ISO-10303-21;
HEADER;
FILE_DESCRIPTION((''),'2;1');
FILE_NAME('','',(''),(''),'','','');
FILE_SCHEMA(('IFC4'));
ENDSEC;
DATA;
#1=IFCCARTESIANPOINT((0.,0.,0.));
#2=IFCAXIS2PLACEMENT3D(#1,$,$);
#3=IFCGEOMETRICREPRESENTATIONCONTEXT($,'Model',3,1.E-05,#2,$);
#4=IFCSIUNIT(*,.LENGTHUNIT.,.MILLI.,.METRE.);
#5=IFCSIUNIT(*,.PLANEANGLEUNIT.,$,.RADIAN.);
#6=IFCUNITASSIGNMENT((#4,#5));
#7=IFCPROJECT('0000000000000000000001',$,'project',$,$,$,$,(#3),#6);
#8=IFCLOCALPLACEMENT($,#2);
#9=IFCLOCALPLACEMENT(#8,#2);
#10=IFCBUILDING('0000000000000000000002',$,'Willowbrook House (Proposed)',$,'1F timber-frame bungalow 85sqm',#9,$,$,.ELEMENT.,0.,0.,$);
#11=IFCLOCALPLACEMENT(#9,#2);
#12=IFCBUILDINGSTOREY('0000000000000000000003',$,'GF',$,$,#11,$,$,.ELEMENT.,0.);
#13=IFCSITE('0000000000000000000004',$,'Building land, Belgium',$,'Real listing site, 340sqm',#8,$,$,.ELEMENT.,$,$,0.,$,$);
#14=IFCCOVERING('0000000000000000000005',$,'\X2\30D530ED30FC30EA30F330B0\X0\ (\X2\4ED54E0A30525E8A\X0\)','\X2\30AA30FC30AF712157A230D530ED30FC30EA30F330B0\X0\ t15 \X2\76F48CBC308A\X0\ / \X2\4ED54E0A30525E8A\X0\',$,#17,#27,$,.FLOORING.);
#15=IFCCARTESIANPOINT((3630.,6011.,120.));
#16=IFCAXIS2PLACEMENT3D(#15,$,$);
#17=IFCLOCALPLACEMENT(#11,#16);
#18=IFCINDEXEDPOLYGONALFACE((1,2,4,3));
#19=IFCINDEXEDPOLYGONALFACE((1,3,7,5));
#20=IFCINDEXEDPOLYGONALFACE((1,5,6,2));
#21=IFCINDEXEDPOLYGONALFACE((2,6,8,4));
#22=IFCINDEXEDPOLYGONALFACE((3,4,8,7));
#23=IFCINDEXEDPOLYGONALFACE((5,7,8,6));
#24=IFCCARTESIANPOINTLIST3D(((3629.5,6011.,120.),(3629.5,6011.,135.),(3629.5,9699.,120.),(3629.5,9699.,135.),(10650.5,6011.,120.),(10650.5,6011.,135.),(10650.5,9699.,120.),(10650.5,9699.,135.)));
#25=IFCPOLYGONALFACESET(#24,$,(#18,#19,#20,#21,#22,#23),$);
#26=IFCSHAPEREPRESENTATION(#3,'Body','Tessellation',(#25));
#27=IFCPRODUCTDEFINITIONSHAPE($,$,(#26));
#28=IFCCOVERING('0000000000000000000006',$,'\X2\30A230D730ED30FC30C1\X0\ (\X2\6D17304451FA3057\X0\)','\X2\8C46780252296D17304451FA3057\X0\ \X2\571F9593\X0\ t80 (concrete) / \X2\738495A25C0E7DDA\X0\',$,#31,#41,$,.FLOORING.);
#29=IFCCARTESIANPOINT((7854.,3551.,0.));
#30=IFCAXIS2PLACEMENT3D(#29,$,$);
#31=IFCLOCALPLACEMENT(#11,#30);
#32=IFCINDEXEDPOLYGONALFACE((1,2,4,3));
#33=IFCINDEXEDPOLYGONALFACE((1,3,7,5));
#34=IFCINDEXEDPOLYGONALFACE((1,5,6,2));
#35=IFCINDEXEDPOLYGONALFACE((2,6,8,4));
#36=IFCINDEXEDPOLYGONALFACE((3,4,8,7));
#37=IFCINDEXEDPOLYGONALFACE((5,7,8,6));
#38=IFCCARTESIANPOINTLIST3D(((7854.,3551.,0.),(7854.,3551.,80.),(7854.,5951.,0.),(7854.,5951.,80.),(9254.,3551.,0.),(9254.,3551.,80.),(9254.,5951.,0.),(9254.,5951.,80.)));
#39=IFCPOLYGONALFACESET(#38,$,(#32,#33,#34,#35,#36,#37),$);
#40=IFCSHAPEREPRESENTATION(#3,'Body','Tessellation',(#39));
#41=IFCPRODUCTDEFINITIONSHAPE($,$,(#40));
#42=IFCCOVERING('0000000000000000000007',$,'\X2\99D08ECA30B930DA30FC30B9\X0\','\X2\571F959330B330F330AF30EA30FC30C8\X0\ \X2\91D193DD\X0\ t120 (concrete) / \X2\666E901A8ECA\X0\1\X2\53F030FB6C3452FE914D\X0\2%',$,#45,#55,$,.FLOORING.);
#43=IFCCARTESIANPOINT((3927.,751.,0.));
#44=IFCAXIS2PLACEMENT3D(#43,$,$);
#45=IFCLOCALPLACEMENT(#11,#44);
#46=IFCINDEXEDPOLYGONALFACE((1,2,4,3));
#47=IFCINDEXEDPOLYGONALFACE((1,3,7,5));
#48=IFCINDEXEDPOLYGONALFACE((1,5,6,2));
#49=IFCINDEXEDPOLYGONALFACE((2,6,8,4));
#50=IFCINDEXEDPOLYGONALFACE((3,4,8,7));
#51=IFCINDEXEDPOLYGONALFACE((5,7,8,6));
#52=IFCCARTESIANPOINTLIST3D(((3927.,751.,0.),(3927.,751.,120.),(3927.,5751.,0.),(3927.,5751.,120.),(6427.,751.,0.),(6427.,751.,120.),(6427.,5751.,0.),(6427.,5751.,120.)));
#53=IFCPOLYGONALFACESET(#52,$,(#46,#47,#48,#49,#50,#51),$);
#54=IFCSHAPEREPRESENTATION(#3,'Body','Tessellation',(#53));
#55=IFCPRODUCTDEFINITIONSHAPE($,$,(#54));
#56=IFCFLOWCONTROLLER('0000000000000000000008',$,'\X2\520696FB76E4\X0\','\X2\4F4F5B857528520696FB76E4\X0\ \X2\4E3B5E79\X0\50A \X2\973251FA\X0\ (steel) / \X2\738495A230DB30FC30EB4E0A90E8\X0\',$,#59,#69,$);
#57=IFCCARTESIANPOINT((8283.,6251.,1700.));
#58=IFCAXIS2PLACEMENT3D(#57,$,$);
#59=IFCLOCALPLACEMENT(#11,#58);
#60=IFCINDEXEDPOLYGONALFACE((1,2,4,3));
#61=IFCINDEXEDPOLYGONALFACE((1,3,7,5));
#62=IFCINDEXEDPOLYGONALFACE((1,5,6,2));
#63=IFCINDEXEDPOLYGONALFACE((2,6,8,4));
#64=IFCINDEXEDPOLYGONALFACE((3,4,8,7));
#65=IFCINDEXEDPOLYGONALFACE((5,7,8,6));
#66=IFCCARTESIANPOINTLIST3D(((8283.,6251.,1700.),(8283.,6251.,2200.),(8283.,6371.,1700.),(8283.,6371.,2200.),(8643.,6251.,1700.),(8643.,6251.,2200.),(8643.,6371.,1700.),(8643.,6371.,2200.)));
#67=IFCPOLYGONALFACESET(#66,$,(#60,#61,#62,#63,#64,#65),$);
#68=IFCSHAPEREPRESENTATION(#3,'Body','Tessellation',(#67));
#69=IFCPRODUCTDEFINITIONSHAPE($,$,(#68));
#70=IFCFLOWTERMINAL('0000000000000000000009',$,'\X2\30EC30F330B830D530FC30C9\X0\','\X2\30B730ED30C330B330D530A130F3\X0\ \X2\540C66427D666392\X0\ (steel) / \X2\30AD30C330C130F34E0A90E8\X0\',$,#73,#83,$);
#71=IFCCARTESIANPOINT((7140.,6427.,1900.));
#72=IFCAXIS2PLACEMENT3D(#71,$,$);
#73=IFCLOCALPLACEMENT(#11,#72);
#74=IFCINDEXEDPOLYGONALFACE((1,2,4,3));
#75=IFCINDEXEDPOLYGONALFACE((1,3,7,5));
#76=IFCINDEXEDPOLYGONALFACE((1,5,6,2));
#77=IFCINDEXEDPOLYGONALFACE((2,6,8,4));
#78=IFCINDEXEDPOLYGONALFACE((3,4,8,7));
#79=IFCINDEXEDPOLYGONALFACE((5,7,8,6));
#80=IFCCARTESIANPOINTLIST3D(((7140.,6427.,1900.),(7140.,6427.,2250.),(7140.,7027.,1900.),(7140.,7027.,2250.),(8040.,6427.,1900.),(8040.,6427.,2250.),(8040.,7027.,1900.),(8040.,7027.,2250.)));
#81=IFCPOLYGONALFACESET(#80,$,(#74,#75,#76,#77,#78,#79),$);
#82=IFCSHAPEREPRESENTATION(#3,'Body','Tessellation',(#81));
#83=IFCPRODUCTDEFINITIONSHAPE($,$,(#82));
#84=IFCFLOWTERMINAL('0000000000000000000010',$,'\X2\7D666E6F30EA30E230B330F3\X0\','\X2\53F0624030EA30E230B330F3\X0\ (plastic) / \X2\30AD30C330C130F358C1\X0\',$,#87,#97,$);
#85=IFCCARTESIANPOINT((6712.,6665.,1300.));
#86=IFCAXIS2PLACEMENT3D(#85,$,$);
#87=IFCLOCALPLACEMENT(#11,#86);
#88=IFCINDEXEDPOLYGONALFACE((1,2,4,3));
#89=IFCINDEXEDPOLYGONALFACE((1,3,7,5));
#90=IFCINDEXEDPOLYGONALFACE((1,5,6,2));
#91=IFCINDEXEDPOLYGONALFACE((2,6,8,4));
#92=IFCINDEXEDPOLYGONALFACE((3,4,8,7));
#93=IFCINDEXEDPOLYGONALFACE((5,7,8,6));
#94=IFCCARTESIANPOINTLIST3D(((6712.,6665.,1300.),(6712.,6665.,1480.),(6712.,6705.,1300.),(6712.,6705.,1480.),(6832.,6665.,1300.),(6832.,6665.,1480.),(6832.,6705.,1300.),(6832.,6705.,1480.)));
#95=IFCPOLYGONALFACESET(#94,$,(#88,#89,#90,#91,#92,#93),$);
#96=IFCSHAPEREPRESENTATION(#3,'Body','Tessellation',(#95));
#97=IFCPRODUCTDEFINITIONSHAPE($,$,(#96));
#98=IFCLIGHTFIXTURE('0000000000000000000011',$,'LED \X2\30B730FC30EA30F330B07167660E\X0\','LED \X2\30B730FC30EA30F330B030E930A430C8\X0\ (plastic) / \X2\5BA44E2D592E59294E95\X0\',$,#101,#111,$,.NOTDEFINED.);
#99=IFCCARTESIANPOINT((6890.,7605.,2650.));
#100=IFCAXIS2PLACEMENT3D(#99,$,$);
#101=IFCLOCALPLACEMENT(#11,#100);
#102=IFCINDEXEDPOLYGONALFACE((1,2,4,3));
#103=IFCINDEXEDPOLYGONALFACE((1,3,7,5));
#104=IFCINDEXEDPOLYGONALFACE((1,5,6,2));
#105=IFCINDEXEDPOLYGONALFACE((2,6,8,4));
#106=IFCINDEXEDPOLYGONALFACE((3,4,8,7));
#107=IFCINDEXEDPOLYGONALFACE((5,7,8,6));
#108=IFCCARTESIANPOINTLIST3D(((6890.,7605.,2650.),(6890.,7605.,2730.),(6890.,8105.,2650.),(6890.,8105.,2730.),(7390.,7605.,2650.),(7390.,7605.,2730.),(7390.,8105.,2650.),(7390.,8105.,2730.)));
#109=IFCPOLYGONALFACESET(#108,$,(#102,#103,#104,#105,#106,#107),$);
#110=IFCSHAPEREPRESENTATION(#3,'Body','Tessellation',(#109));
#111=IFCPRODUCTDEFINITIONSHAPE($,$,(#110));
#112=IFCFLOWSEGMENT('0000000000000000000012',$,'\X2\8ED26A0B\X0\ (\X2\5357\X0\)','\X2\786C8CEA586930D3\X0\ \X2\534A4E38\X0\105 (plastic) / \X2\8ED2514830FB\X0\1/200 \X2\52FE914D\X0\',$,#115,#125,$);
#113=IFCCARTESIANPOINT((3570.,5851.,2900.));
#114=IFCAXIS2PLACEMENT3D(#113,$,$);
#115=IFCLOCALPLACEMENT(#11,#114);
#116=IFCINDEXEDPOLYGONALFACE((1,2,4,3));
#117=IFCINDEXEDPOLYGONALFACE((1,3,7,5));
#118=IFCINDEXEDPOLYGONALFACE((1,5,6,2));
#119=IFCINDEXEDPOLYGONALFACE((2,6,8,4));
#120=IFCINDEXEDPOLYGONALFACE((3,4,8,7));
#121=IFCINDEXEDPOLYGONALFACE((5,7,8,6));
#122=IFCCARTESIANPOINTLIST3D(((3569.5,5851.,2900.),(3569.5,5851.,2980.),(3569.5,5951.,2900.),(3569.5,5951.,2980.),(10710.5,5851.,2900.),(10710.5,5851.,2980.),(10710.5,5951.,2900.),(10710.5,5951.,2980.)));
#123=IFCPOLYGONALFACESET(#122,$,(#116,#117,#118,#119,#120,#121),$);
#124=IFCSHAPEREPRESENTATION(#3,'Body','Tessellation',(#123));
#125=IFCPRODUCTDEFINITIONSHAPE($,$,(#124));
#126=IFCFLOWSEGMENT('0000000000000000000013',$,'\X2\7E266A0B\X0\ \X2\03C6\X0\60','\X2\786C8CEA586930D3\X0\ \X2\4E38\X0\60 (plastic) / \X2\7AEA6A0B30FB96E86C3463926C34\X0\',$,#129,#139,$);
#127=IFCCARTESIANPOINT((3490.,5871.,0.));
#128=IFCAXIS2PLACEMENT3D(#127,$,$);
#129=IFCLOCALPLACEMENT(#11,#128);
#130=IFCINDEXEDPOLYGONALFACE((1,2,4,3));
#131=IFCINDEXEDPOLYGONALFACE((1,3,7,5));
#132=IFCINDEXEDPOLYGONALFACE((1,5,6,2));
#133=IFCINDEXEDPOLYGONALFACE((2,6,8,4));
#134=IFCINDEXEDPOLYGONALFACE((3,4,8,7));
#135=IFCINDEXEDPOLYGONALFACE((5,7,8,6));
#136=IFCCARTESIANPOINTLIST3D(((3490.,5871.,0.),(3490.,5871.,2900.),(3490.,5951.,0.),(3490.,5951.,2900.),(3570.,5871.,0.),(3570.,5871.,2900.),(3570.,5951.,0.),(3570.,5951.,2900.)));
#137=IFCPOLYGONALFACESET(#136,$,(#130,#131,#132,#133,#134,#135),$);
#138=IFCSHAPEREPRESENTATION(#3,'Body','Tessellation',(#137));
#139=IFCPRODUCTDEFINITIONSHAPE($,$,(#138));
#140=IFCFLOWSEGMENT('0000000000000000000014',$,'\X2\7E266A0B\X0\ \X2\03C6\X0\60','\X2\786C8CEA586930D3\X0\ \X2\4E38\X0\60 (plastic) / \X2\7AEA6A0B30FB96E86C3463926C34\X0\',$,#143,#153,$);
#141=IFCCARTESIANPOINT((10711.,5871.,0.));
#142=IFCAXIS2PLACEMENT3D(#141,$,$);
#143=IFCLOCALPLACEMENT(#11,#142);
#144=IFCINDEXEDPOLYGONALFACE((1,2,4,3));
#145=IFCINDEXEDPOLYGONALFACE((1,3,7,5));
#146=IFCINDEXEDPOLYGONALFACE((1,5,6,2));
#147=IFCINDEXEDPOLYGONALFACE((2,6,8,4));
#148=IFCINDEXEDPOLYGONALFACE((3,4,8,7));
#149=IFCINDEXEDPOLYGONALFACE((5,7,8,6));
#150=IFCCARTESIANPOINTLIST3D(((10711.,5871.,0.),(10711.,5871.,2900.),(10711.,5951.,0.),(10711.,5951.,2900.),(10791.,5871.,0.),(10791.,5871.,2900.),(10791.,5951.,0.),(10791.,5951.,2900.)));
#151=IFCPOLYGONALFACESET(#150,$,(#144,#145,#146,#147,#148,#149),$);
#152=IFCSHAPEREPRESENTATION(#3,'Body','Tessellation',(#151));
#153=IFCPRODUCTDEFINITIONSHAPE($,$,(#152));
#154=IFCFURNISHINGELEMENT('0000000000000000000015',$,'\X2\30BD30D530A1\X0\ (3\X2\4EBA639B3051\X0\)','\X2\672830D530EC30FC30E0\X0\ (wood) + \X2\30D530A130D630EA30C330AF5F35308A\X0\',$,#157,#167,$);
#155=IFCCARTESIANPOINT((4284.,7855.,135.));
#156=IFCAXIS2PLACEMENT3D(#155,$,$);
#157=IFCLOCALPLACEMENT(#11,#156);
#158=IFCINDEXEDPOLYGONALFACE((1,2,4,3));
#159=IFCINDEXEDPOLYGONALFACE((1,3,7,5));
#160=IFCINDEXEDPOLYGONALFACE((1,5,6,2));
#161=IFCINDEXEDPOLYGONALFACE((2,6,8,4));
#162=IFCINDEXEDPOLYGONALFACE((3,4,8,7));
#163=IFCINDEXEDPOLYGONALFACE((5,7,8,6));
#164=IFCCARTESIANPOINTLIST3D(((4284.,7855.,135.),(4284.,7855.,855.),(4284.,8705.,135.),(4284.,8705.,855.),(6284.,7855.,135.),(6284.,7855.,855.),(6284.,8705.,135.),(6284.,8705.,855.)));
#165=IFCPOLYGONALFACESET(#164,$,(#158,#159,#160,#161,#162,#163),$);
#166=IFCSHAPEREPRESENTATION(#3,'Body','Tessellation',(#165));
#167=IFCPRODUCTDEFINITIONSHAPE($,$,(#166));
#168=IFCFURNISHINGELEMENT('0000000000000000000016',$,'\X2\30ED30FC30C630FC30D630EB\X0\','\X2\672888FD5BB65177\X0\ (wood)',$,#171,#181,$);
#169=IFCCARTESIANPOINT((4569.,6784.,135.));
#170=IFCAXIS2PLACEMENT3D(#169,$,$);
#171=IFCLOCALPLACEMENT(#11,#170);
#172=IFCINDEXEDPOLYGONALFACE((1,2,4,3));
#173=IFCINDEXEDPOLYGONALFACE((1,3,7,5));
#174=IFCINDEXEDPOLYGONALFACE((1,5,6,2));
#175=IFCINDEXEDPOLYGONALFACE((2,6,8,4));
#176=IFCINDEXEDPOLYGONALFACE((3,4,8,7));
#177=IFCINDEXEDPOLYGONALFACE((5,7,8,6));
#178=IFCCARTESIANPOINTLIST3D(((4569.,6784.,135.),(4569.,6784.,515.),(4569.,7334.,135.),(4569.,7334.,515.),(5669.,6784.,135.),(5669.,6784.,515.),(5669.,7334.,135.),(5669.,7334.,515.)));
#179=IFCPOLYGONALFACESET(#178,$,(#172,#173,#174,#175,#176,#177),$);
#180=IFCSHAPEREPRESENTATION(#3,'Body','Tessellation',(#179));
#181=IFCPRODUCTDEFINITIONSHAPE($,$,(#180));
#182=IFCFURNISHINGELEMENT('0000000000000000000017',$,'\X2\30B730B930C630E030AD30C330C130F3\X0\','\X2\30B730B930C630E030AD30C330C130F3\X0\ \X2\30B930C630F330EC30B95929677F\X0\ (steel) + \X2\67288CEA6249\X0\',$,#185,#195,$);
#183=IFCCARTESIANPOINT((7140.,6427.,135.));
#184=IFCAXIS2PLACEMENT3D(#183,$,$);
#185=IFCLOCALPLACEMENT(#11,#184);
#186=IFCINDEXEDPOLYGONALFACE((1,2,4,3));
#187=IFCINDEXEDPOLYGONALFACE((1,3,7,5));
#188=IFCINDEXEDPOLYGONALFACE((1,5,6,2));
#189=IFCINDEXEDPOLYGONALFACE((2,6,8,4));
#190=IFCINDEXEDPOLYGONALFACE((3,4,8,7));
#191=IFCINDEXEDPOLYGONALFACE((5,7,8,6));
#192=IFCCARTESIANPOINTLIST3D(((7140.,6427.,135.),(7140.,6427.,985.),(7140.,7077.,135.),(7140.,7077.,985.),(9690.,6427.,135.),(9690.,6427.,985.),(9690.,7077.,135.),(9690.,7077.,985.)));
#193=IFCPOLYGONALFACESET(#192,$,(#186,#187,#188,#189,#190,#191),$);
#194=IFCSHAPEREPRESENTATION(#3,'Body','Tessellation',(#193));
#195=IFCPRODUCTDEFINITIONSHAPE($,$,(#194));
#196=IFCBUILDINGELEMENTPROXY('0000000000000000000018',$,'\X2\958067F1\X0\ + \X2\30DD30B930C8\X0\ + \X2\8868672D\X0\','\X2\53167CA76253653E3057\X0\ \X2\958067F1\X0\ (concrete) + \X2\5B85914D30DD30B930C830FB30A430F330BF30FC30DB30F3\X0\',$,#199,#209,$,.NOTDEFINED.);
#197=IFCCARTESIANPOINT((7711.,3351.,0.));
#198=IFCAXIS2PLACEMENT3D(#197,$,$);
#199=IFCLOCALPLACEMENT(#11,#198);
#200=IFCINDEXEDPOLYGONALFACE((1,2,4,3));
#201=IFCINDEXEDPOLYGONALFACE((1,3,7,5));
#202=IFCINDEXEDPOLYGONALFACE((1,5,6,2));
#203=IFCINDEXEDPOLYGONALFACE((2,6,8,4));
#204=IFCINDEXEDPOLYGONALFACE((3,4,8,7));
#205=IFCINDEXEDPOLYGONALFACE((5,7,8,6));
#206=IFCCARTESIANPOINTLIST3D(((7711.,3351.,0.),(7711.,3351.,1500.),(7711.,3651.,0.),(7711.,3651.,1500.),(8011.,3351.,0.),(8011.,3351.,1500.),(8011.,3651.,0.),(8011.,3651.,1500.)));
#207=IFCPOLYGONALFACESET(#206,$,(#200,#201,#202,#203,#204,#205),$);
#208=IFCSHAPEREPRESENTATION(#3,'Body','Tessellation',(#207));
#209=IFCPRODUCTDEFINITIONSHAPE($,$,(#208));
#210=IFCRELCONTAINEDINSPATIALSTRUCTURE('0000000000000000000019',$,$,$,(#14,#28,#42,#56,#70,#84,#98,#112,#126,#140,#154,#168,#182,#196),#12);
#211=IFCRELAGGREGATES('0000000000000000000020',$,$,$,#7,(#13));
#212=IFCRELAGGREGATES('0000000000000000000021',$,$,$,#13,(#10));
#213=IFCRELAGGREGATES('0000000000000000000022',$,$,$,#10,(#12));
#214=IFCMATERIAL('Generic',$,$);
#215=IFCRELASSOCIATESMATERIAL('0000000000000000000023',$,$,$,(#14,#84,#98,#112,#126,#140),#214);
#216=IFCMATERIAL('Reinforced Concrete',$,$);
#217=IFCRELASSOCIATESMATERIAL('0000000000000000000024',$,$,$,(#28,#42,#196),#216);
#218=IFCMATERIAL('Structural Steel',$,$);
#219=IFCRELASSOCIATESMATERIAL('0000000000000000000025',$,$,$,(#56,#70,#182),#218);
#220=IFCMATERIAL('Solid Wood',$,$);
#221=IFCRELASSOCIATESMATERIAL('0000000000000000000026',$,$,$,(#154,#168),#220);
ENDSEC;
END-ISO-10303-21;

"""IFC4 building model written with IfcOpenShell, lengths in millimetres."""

from ifc_helpers import new_model, si_unit, frame, frame_2d, origin, place, context, project, spatial, rectangle, extrude, material, element, save


model = new_model("IFC4")

# Units and contexts
model_context = context("Model", 3, precision=1e-05, world=origin())
ifc_project = project(units=[si_unit("LENGTHUNIT", "METRE", prefix="MILLI"), si_unit("PLANEANGLEUNIT", "RADIAN")], contexts=[model_context])

# Site, building, storey
site_placement = place(None, origin())
site = spatial("IfcSite", under=ifc_project, at=site_placement, Name="Building land, Belgium", ObjectType="Real listing site, 340sqm", CompositionType="ELEMENT", RefElevation=0.0)
building_placement = place(site_placement, origin())
building = spatial("IfcBuilding", under=site, at=building_placement, Name="Willowbrook House (Proposed)", ObjectType="1F timber-frame bungalow 85sqm", CompositionType="ELEMENT", ElevationOfRefHeight=0.0, ElevationOfTerrain=0.0)
storey_placement = place(building_placement, origin())
storey = spatial("IfcBuildingStorey", under=building, at=storey_placement, Name="GF", CompositionType="ELEMENT", Elevation=0.0)

# Shared definitions
ifc_material_1 = material(Name="Solid Wood")

# Shared definitions
ifc_material_2 = material(Name="Reinforced Concrete")

# Shared definitions
ifc_material_3 = material(Name="Structural Steel")

# Coverings
ifc_material_4 = material(Name="Generic")
covering_1_placement = place(storey_placement, frame((3630.0, 6011.0, 120.0)))
element("IfcCovering", 1, at=covering_1_placement, inside=storey, material=ifc_material_4, Name="フローリング (仕上げ床)", Description="オーク無垢フローリング t15 直貼り / 仕上げ床", PredefinedType="FLOORING", context=model_context, shape_type="SweptSolid", body=[
    extrude(rectangle(XDim=7021.0, YDim=3688.0, at=frame_2d((3510.0, 1844.0))), frame((3630.0, 6011.0, 120.0)), (0.0, 0.0, 1.0), 15.0),
])
covering_2_placement = place(storey_placement, frame((7854.0, 3551.0, 0.0)))
element("IfcCovering", 2, at=covering_2_placement, inside=storey, material=ifc_material_2, Name="アプローチ (洗い出し)", Description="豆砂利洗い出し 土間 t80 (concrete) / 玄関導線", PredefinedType="FLOORING", context=model_context, shape_type="SweptSolid", body=[
    extrude(rectangle(XDim=1400.0, YDim=2400.0, at=frame_2d((700.0, 1200.0))), frame((7854.0, 3551.0, 0.0)), (0.0, 0.0, 1.0), 80.0),
])
covering_3_placement = place(storey_placement, frame((3927.0, 751.0, 0.0)))
element("IfcCovering", 3, at=covering_3_placement, inside=storey, material=ifc_material_2, Name="駐車スペース", Description="土間コンクリート 金鏝 t120 (concrete) / 普通車1台・水勾配2%", PredefinedType="FLOORING", context=model_context, shape_type="SweptSolid", body=[
    extrude(rectangle(XDim=2500.0, YDim=5000.0, at=frame_2d((1250.0, 2500.0))), frame((3927.0, 751.0, 0.0)), (0.0, 0.0, 1.0), 120.0),
])

# Flow controller
flow_controller_placement = place(storey_placement, frame((8283.0, 6251.0, 1700.0)))
element("IfcFlowController", 4, at=flow_controller_placement, inside=storey, material=ifc_material_3, Name="分電盤", Description="住宅用分電盤 主幹50A 露出 (steel) / 玄関ホール上部", context=model_context, shape_type="SweptSolid", body=[
    extrude(rectangle(XDim=360.0, YDim=120.0, at=frame_2d((180.0, 60.0))), frame((8283.0, 6251.0, 1700.0)), (0.0, 0.0, 1.0), 500.0),
])

# Flow terminals
flow_terminal_1_placement = place(storey_placement, frame((7140.0, 6427.0, 1900.0)))
element("IfcFlowTerminal", 5, at=flow_terminal_1_placement, inside=storey, material=ifc_material_3, Name="レンジフード", Description="シロッコファン 同時給排 (steel) / キッチン上部", context=model_context, shape_type="SweptSolid", body=[
    extrude(rectangle(XDim=900.0, YDim=600.0, at=frame_2d((450.0, 300.0))), frame((7140.0, 6427.0, 1900.0)), (0.0, 0.0, 1.0), 350.0),
])
flow_terminal_2_placement = place(storey_placement, frame((6712.0, 6665.0, 1300.0)))
element("IfcFlowTerminal", 6, at=flow_terminal_2_placement, inside=storey, material=ifc_material_4, Name="給湯リモコン", Description="台所リモコン (plastic) / キッチン壁", context=model_context, shape_type="SweptSolid", body=[
    extrude(rectangle(XDim=120.0, YDim=40.0, at=frame_2d((60.0, 20.0))), frame((6712.0, 6665.0, 1300.0)), (0.0, 0.0, 1.0), 180.0),
])

# Light fixture
light_fixture_placement = place(storey_placement, frame((6890.0, 7605.0, 2650.0)))
element("IfcLightFixture", 7, at=light_fixture_placement, inside=storey, material=ifc_material_4, Name="LED シーリング照明", Description="LED シーリングライト (plastic) / 室中央天井", PredefinedType="NOTDEFINED", context=model_context, shape_type="SweptSolid", body=[
    extrude(rectangle(XDim=500.0, YDim=500.0, at=frame_2d((250.0, 250.0))), frame((6890.0, 7605.0, 2650.0)), (0.0, 0.0, 1.0), 80.0),
])

# Flow segments
flow_segment_1_placement = place(storey_placement, frame((3570.0, 5851.0, 2900.0)))
element("IfcFlowSegment", 8, at=flow_segment_1_placement, inside=storey, material=ifc_material_4, Name="軒樋 (南)", Description="硬質塩ビ 半丸105 (plastic) / 軒先・1/200 勾配", context=model_context, shape_type="SweptSolid", body=[
    extrude(rectangle(XDim=7141.0, YDim=100.0, at=frame_2d((3570.0, 50.0))), frame((3570.0, 5851.0, 2900.0)), (0.0, 0.0, 1.0), 80.0),
])
flow_segment_2_placement = place(storey_placement, frame((3490.0, 5871.0, 0.0)))
element("IfcFlowSegment", 9, at=flow_segment_2_placement, inside=storey, material=ifc_material_4, Name="縦樋 φ60", Description="硬質塩ビ 丸60 (plastic) / 竪樋・雨水排水", context=model_context, shape_type="SweptSolid", body=[
    extrude(rectangle(XDim=80.0, YDim=80.0, at=frame_2d((40.0, 40.0))), frame((3490.0, 5871.0, 0.0)), (0.0, 0.0, 1.0), 2900.0),
])
flow_segment_3_placement = place(storey_placement, frame((10711.0, 5871.0, 0.0)))
element("IfcFlowSegment", 10, at=flow_segment_3_placement, inside=storey, material=ifc_material_4, Name="縦樋 φ60", Description="硬質塩ビ 丸60 (plastic) / 竪樋・雨水排水", context=model_context, shape_type="SweptSolid", body=[
    extrude(rectangle(XDim=80.0, YDim=80.0, at=frame_2d((40.0, 40.0))), frame((10711.0, 5871.0, 0.0)), (0.0, 0.0, 1.0), 2900.0),
])

# Furnishing elements
furnishing_1_placement = place(storey_placement, frame((4284.0, 7855.0, 135.0)))
element("IfcFurnishingElement", 11, at=furnishing_1_placement, inside=storey, material=ifc_material_1, Name="ソファ (3人掛け)", Description="木フレーム (wood) + ファブリック張り", context=model_context, shape_type="SweptSolid", body=[
    extrude(rectangle(XDim=2000.0, YDim=850.0, at=frame_2d((1000.0, 425.0))), frame((4284.0, 7855.0, 135.0)), (0.0, 0.0, 1.0), 720.0),
])
furnishing_2_placement = place(storey_placement, frame((4569.0, 6784.0, 135.0)))
element("IfcFurnishingElement", 12, at=furnishing_2_placement, inside=storey, material=ifc_material_1, Name="ローテーブル", Description="木製家具 (wood)", context=model_context, shape_type="SweptSolid", body=[
    extrude(rectangle(XDim=1100.0, YDim=550.0, at=frame_2d((550.0, 275.0))), frame((4569.0, 6784.0, 135.0)), (0.0, 0.0, 1.0), 380.0),
])
furnishing_3_placement = place(storey_placement, frame((7140.0, 6427.0, 135.0)))
element("IfcFurnishingElement", 13, at=furnishing_3_placement, inside=storey, material=ifc_material_3, Name="システムキッチン", Description="システムキッチン ステンレス天板 (steel) + 木質扉", context=model_context, shape_type="SweptSolid", body=[
    extrude(rectangle(XDim=2550.0, YDim=650.0, at=frame_2d((1275.0, 325.0))), frame((7140.0, 6427.0, 135.0)), (0.0, 0.0, 1.0), 850.0),
])

# Building element proxy
proxy_placement = place(storey_placement, frame((7711.0, 3351.0, 0.0)))
element("IfcBuildingElementProxy", 14, at=proxy_placement, inside=storey, material=ifc_material_2, Name="門柱 + ポスト + 表札", Description="化粧打放し 門柱 (concrete) + 宅配ポスト・インターホン", PredefinedType="NOTDEFINED", context=model_context, shape_type="SweptSolid", body=[
    extrude(rectangle(XDim=300.0, YDim=300.0, at=frame_2d((150.0, 150.0))), frame((7711.0, 3351.0, 0.0)), (0.0, 0.0, 1.0), 1500.0),
])

save(model, "model.ifc")
